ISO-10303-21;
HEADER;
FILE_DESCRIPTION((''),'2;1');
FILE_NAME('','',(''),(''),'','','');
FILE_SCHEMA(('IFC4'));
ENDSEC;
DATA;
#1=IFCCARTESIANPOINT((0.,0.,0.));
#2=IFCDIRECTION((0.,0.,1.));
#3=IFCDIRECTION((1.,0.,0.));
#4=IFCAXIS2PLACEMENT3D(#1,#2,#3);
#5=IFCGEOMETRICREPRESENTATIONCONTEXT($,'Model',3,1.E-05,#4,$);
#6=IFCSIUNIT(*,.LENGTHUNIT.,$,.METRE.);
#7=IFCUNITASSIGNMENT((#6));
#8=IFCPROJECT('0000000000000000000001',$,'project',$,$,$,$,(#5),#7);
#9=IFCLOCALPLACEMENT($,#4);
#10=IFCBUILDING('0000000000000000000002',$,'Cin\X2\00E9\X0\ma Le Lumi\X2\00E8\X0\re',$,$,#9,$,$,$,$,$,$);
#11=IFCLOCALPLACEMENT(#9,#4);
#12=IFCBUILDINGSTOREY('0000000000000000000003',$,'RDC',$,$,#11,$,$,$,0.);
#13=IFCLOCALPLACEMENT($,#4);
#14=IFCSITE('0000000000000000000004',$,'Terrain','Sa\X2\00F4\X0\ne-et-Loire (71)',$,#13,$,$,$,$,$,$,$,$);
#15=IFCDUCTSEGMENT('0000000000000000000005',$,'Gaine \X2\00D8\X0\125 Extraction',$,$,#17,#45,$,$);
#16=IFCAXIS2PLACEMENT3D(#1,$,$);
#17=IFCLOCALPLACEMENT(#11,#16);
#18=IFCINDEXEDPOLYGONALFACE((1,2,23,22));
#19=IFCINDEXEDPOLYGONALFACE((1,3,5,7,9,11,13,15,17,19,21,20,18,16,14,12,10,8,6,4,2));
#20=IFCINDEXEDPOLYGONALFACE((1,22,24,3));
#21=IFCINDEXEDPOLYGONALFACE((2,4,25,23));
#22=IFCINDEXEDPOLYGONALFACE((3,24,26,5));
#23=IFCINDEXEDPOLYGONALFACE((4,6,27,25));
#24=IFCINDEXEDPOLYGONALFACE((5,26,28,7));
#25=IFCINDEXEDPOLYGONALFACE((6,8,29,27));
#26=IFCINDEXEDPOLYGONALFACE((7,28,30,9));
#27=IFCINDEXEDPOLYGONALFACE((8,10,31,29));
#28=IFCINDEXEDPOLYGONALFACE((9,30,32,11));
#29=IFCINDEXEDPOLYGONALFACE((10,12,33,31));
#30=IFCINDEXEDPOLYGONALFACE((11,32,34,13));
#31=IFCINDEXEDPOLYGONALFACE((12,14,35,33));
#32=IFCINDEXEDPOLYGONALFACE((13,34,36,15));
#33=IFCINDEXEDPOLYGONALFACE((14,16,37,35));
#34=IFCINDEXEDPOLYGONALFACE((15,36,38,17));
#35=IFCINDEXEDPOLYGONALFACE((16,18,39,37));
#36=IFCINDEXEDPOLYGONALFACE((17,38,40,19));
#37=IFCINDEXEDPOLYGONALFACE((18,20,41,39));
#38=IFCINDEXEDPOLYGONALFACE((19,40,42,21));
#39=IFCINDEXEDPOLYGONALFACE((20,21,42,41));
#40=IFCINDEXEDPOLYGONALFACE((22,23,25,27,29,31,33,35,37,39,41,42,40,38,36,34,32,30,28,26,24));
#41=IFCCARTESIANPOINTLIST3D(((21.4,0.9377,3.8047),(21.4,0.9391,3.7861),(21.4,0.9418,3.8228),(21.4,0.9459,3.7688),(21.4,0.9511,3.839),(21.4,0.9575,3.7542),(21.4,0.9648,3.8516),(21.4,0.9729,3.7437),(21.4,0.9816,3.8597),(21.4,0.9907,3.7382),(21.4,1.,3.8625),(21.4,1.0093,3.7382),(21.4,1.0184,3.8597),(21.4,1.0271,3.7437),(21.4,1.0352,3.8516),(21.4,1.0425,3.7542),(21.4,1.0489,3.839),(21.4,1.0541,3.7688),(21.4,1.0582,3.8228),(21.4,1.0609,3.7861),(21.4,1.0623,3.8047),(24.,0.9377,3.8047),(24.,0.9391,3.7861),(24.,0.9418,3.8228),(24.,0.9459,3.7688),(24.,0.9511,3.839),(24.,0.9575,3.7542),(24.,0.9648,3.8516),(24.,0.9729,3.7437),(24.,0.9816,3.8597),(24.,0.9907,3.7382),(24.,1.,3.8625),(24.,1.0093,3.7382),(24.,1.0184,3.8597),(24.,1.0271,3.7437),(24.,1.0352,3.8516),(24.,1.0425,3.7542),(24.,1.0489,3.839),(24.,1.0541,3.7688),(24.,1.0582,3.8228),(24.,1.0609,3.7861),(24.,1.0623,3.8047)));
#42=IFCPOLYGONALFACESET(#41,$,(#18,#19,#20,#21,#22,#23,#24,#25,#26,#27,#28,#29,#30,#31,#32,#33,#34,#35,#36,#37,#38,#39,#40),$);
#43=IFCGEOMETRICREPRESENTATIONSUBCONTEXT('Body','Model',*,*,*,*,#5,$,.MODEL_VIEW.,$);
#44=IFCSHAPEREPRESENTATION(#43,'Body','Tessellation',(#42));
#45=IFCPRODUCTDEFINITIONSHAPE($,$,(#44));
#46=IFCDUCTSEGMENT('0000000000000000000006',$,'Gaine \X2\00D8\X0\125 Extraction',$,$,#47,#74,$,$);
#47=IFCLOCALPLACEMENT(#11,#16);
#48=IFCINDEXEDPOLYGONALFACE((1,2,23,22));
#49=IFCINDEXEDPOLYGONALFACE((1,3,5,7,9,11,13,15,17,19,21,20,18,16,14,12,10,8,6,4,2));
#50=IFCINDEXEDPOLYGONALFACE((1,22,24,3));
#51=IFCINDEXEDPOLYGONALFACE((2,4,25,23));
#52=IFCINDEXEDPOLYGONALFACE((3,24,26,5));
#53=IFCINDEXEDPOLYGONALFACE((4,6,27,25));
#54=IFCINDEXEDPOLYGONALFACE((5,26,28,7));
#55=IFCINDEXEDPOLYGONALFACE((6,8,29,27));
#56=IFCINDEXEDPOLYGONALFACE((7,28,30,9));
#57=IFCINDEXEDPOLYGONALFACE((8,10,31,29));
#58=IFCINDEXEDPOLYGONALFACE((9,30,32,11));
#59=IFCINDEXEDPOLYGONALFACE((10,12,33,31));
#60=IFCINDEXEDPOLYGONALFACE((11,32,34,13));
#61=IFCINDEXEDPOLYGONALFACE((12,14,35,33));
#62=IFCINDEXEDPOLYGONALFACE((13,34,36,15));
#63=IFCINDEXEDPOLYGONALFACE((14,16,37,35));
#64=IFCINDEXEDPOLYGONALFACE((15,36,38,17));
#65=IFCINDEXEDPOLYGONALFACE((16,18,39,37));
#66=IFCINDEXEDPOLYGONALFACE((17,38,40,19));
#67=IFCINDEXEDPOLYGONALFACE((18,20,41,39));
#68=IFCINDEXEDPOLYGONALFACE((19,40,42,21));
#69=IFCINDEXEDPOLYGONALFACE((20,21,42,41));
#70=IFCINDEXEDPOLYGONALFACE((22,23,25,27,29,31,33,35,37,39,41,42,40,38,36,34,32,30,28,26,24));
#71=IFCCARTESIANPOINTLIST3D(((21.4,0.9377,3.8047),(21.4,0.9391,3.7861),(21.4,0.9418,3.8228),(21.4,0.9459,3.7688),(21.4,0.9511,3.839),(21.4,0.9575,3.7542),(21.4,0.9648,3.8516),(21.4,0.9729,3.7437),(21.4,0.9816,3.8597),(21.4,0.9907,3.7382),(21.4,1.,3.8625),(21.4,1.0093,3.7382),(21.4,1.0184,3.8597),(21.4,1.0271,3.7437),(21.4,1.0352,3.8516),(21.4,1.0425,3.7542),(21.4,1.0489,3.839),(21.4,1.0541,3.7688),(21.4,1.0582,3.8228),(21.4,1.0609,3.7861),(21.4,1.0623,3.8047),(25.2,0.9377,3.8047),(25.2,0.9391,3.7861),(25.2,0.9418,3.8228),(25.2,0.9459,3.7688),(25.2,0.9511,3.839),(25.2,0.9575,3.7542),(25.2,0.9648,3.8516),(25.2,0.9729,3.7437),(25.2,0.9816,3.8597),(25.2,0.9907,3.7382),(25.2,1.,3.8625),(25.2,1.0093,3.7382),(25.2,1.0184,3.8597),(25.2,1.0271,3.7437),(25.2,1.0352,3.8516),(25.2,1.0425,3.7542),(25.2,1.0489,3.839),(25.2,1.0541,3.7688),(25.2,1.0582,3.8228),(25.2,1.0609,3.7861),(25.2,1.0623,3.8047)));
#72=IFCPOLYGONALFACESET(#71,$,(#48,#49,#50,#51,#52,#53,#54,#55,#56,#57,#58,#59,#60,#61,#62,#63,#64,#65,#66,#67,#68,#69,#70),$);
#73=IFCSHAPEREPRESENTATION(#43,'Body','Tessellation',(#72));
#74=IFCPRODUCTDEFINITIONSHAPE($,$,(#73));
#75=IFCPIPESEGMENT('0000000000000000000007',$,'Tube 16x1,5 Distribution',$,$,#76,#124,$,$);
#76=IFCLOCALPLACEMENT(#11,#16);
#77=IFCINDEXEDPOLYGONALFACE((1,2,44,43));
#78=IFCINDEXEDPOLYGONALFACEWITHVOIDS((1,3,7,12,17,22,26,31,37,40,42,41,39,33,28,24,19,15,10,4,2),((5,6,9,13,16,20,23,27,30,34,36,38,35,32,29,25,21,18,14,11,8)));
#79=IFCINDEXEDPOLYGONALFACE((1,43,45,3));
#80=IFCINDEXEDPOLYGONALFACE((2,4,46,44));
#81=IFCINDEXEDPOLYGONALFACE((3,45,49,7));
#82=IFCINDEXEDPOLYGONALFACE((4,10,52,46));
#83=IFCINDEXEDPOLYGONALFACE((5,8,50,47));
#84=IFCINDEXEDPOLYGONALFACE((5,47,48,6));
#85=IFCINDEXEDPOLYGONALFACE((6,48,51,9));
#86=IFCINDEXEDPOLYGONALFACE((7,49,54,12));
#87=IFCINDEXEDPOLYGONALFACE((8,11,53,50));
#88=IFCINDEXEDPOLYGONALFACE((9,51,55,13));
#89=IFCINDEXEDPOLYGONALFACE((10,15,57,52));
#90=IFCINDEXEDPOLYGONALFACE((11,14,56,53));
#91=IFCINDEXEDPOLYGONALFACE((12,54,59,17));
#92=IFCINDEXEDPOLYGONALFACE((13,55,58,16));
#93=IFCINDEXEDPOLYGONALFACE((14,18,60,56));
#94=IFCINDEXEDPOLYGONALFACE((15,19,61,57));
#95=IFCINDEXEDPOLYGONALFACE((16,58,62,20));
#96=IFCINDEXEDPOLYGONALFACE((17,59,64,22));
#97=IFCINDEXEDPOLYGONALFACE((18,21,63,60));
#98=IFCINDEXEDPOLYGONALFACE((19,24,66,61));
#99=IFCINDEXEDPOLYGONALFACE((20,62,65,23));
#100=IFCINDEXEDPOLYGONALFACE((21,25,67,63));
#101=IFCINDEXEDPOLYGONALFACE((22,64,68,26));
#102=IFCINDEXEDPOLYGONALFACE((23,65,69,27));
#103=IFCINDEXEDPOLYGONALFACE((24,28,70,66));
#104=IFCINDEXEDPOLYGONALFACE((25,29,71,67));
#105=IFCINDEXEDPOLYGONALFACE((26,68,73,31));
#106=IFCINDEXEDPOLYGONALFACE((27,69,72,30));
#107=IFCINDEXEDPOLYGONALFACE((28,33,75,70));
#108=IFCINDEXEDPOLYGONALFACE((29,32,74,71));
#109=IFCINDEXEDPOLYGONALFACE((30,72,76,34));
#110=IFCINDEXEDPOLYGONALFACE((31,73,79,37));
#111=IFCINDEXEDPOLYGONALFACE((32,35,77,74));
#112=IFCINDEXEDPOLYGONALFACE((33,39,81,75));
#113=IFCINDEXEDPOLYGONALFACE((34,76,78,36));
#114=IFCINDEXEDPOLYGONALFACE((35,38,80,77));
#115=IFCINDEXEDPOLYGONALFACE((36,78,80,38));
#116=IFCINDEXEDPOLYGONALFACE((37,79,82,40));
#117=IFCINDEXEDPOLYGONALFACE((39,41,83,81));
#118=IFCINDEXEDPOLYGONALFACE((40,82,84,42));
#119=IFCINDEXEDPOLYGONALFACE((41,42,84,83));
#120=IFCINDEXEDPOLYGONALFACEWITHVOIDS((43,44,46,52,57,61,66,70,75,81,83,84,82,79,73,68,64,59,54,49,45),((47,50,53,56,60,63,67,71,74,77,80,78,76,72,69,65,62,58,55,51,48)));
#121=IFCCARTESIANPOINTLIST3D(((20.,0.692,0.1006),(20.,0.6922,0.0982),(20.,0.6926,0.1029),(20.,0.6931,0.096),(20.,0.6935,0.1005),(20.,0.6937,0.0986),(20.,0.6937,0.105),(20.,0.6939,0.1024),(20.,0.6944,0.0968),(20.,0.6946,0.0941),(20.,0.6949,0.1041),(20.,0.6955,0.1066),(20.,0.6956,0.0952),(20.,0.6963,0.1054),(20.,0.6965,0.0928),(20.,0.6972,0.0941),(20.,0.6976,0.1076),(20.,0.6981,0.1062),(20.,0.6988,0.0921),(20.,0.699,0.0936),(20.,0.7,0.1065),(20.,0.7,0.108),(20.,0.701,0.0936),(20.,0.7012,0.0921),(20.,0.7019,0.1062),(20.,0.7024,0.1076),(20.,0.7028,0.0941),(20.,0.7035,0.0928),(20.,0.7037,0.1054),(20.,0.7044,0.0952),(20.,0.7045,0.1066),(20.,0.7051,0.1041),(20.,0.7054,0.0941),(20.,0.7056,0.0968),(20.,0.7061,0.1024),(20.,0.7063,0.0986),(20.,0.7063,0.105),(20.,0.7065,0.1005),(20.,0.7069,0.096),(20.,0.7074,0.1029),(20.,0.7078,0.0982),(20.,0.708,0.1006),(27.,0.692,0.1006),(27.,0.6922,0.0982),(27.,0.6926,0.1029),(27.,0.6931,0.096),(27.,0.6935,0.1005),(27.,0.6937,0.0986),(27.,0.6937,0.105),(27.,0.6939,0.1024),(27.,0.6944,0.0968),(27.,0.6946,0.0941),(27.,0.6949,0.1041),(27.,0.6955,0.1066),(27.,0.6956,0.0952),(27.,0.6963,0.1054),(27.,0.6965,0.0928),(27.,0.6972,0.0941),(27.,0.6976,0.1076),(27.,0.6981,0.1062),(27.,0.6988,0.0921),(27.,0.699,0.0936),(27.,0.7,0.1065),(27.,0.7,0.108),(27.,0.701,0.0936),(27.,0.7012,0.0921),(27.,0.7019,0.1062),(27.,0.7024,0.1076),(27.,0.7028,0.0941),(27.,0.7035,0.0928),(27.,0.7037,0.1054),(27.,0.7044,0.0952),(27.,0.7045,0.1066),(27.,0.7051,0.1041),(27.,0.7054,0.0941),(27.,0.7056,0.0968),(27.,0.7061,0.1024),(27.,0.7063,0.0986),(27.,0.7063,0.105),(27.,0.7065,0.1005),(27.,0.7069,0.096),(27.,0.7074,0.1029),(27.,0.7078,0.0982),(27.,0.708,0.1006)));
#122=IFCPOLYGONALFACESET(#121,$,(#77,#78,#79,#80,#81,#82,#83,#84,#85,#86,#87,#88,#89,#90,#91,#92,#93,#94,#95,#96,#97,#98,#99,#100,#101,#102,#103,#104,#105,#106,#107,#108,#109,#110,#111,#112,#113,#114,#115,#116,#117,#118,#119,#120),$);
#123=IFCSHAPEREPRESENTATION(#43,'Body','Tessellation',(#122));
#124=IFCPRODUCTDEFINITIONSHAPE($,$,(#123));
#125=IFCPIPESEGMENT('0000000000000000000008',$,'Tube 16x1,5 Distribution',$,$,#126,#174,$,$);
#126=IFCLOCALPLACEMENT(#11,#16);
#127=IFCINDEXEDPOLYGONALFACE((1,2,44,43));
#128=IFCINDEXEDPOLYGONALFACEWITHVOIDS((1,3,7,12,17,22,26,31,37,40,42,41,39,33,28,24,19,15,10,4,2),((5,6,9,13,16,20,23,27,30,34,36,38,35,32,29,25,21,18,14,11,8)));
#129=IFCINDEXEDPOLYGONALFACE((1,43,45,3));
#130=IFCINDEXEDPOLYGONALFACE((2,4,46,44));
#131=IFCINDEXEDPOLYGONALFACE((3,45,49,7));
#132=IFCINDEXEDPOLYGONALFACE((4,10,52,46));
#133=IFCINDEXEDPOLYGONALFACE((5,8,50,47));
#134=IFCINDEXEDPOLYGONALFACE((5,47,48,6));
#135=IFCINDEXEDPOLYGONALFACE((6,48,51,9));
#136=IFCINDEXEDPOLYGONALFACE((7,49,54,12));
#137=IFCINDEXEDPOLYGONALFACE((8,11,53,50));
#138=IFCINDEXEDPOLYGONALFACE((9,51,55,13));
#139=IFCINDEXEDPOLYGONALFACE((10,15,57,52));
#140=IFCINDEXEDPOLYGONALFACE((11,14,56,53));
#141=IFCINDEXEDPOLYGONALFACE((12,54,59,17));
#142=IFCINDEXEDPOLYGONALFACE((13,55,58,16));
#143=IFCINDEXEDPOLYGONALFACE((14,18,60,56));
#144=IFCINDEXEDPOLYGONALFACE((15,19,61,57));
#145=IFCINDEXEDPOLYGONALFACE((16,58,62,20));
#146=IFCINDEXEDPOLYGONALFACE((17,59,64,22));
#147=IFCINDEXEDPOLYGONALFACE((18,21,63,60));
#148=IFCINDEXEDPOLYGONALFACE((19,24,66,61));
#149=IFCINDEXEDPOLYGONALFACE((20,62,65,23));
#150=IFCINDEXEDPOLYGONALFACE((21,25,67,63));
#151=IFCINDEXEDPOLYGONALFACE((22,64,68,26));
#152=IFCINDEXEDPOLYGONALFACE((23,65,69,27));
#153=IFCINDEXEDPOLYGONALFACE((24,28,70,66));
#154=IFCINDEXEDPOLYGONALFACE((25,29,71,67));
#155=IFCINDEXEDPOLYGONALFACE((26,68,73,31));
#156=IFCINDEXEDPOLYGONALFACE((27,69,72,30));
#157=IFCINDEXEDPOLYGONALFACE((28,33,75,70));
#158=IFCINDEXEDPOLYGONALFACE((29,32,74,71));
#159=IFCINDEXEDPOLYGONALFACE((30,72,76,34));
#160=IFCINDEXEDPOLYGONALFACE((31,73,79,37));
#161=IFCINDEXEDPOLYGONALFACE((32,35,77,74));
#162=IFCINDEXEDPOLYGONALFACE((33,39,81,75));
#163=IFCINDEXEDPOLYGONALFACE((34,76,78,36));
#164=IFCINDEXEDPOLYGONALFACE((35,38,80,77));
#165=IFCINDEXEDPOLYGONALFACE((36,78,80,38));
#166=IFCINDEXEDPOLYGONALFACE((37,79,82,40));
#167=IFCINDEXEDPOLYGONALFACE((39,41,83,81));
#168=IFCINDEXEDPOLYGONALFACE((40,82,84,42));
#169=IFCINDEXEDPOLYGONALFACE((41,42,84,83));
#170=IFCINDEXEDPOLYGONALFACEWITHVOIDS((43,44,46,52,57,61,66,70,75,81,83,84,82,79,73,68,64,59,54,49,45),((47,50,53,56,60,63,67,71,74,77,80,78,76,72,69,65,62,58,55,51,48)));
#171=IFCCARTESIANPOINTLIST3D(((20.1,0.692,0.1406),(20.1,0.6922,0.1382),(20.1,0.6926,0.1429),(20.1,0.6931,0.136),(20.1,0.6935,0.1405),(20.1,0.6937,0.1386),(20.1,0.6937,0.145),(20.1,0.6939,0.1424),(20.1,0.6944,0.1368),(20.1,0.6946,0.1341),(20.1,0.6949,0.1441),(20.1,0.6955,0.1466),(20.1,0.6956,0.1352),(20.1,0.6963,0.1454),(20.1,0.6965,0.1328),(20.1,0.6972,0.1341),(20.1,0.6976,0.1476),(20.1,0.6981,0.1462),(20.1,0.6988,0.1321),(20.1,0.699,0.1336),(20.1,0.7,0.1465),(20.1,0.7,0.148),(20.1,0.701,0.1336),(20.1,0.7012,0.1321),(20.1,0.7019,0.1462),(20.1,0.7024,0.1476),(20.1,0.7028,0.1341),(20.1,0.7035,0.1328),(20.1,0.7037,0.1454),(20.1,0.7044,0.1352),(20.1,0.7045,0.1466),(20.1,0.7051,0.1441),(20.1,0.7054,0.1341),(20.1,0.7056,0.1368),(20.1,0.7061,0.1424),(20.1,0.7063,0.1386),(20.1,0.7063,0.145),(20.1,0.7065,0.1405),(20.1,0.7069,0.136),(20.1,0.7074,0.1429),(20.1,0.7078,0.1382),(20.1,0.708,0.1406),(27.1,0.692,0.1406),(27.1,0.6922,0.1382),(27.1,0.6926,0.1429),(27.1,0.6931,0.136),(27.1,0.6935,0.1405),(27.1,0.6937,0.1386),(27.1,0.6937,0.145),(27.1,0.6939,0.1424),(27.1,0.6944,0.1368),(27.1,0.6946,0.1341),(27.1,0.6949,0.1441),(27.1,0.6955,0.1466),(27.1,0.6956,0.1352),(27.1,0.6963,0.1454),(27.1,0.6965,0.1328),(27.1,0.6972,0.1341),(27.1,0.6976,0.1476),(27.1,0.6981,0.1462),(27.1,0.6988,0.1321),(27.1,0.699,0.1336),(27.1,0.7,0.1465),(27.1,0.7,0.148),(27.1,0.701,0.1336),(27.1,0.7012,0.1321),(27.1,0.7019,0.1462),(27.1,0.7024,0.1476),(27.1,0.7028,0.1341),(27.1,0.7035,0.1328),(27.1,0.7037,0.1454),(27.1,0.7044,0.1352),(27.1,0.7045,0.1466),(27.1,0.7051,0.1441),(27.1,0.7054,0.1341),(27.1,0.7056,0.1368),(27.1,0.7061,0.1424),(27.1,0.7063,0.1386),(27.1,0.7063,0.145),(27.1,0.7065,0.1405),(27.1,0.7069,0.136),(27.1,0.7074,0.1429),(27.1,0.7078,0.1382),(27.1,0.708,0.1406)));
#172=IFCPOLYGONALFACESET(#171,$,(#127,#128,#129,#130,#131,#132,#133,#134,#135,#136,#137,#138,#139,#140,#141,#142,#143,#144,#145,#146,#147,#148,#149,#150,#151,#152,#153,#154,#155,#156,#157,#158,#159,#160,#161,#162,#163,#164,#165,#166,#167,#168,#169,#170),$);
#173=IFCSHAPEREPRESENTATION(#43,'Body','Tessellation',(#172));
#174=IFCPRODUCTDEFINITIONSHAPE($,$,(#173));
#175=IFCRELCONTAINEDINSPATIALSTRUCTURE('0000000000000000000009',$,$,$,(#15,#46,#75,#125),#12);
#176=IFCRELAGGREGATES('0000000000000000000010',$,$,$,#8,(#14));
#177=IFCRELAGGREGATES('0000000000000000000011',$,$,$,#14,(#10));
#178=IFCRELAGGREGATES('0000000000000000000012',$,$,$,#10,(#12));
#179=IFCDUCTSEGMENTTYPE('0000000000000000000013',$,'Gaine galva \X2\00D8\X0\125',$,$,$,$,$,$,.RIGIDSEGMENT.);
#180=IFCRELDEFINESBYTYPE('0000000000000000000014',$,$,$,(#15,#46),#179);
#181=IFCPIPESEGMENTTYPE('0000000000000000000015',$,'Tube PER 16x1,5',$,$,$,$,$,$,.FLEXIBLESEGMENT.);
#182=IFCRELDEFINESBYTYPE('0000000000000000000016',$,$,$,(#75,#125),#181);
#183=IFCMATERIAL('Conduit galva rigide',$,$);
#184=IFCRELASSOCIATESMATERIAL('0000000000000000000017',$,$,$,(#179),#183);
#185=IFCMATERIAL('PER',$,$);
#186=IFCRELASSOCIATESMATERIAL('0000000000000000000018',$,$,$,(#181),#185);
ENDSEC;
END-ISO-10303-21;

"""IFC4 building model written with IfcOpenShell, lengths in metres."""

from ifc_helpers import new_model, si_unit, frame, origin_with_axes, place, context, subcontext, project, spatial, circle, hollow_circle, extrude, material, type_object, element, save


model = new_model("IFC4")

# Units and contexts
model_context = context("Model", 3, precision=1e-05, world=origin_with_axes())
body_context = subcontext(model_context, "Body", "Model", "MODEL_VIEW")
ifc_project = project(units=[si_unit("LENGTHUNIT", "METRE")], contexts=[model_context])

# Site, building, storey
site_placement = place(None, origin_with_axes())
site = spatial("IfcSite", under=ifc_project, at=site_placement, Name="Terrain", Description="Saône-et-Loire (71)")
building_placement = place(None, origin_with_axes())
building = spatial("IfcBuilding", under=site, at=building_placement, Name="Cinéma Le Lumière")
storey_placement = place(building_placement, origin_with_axes())
storey = spatial("IfcBuildingStorey", under=building, at=storey_placement, Name="RDC", Elevation=0.0)

# Duct segments
ifc_material_1 = material(Name="Conduit galva rigide")
duct_segment_type_1 = type_object("IfcDuctSegmentType", Name="Gaine galva Ø125", PredefinedType="RIGIDSEGMENT", material=ifc_material_1)
duct_segment_1_placement = place(storey_placement, frame((24.0, 1.0, 3.8), z_axis=(-1.0, 0.0, 0.0), x_axis=(0.0, 0.0, 1.0)))
element("IfcDuctSegment", 1, at=duct_segment_1_placement, inside=storey, type_object=duct_segment_type_1, Name="Gaine Ø125 Extraction", context=body_context, shape_type="SweptSolid", body=[
    extrude(circle(Radius=0.0625), origin_with_axes(), (0.0, 0.0, 1.0), 2.6),
])
duct_segment_2_placement = place(storey_placement, frame((25.2, 1.0, 3.8), z_axis=(-1.0, 0.0, 0.0), x_axis=(0.0, 0.0, 1.0)))
element("IfcDuctSegment", 2, at=duct_segment_2_placement, inside=storey, type_object=duct_segment_type_1, Name="Gaine Ø125 Extraction", context=body_context, shape_type="SweptSolid", body=[
    extrude(circle(Radius=0.0625), origin_with_axes(), (0.0, 0.0, 1.0), 3.8),
])

# Pipe segments
ifc_material_2 = material(Name="PER")
pipe_segment_type_1 = type_object("IfcPipeSegmentType", Name="Tube PER 16x1,5", PredefinedType="FLEXIBLESEGMENT", material=ifc_material_2)
for number, where, z_axis, x_axis, name in (
    (3, (27.0, 0.7, 0.1), (-1.0, 0.0, 0.0), (0.0, 0.0, 1.0), "Tube 16x1,5 Distribution"),
    (4, (27.1, 0.7, 0.14), (-1.0, 0.0, 0.0), (0.0, 0.0, 1.0), "Tube 16x1,5 Distribution"),
):
    element("IfcPipeSegment", number, at=place(storey_placement, frame(where, z_axis=z_axis, x_axis=x_axis)), inside=storey, type_object=pipe_segment_type_1, Name=name, context=body_context, shape_type="SweptSolid", body=[
        extrude(hollow_circle(Radius=0.008, WallThickness=0.0015), origin_with_axes(), (0.0, 0.0, 1.0), 7.0),
    ])

save(model, "model.ifc")
